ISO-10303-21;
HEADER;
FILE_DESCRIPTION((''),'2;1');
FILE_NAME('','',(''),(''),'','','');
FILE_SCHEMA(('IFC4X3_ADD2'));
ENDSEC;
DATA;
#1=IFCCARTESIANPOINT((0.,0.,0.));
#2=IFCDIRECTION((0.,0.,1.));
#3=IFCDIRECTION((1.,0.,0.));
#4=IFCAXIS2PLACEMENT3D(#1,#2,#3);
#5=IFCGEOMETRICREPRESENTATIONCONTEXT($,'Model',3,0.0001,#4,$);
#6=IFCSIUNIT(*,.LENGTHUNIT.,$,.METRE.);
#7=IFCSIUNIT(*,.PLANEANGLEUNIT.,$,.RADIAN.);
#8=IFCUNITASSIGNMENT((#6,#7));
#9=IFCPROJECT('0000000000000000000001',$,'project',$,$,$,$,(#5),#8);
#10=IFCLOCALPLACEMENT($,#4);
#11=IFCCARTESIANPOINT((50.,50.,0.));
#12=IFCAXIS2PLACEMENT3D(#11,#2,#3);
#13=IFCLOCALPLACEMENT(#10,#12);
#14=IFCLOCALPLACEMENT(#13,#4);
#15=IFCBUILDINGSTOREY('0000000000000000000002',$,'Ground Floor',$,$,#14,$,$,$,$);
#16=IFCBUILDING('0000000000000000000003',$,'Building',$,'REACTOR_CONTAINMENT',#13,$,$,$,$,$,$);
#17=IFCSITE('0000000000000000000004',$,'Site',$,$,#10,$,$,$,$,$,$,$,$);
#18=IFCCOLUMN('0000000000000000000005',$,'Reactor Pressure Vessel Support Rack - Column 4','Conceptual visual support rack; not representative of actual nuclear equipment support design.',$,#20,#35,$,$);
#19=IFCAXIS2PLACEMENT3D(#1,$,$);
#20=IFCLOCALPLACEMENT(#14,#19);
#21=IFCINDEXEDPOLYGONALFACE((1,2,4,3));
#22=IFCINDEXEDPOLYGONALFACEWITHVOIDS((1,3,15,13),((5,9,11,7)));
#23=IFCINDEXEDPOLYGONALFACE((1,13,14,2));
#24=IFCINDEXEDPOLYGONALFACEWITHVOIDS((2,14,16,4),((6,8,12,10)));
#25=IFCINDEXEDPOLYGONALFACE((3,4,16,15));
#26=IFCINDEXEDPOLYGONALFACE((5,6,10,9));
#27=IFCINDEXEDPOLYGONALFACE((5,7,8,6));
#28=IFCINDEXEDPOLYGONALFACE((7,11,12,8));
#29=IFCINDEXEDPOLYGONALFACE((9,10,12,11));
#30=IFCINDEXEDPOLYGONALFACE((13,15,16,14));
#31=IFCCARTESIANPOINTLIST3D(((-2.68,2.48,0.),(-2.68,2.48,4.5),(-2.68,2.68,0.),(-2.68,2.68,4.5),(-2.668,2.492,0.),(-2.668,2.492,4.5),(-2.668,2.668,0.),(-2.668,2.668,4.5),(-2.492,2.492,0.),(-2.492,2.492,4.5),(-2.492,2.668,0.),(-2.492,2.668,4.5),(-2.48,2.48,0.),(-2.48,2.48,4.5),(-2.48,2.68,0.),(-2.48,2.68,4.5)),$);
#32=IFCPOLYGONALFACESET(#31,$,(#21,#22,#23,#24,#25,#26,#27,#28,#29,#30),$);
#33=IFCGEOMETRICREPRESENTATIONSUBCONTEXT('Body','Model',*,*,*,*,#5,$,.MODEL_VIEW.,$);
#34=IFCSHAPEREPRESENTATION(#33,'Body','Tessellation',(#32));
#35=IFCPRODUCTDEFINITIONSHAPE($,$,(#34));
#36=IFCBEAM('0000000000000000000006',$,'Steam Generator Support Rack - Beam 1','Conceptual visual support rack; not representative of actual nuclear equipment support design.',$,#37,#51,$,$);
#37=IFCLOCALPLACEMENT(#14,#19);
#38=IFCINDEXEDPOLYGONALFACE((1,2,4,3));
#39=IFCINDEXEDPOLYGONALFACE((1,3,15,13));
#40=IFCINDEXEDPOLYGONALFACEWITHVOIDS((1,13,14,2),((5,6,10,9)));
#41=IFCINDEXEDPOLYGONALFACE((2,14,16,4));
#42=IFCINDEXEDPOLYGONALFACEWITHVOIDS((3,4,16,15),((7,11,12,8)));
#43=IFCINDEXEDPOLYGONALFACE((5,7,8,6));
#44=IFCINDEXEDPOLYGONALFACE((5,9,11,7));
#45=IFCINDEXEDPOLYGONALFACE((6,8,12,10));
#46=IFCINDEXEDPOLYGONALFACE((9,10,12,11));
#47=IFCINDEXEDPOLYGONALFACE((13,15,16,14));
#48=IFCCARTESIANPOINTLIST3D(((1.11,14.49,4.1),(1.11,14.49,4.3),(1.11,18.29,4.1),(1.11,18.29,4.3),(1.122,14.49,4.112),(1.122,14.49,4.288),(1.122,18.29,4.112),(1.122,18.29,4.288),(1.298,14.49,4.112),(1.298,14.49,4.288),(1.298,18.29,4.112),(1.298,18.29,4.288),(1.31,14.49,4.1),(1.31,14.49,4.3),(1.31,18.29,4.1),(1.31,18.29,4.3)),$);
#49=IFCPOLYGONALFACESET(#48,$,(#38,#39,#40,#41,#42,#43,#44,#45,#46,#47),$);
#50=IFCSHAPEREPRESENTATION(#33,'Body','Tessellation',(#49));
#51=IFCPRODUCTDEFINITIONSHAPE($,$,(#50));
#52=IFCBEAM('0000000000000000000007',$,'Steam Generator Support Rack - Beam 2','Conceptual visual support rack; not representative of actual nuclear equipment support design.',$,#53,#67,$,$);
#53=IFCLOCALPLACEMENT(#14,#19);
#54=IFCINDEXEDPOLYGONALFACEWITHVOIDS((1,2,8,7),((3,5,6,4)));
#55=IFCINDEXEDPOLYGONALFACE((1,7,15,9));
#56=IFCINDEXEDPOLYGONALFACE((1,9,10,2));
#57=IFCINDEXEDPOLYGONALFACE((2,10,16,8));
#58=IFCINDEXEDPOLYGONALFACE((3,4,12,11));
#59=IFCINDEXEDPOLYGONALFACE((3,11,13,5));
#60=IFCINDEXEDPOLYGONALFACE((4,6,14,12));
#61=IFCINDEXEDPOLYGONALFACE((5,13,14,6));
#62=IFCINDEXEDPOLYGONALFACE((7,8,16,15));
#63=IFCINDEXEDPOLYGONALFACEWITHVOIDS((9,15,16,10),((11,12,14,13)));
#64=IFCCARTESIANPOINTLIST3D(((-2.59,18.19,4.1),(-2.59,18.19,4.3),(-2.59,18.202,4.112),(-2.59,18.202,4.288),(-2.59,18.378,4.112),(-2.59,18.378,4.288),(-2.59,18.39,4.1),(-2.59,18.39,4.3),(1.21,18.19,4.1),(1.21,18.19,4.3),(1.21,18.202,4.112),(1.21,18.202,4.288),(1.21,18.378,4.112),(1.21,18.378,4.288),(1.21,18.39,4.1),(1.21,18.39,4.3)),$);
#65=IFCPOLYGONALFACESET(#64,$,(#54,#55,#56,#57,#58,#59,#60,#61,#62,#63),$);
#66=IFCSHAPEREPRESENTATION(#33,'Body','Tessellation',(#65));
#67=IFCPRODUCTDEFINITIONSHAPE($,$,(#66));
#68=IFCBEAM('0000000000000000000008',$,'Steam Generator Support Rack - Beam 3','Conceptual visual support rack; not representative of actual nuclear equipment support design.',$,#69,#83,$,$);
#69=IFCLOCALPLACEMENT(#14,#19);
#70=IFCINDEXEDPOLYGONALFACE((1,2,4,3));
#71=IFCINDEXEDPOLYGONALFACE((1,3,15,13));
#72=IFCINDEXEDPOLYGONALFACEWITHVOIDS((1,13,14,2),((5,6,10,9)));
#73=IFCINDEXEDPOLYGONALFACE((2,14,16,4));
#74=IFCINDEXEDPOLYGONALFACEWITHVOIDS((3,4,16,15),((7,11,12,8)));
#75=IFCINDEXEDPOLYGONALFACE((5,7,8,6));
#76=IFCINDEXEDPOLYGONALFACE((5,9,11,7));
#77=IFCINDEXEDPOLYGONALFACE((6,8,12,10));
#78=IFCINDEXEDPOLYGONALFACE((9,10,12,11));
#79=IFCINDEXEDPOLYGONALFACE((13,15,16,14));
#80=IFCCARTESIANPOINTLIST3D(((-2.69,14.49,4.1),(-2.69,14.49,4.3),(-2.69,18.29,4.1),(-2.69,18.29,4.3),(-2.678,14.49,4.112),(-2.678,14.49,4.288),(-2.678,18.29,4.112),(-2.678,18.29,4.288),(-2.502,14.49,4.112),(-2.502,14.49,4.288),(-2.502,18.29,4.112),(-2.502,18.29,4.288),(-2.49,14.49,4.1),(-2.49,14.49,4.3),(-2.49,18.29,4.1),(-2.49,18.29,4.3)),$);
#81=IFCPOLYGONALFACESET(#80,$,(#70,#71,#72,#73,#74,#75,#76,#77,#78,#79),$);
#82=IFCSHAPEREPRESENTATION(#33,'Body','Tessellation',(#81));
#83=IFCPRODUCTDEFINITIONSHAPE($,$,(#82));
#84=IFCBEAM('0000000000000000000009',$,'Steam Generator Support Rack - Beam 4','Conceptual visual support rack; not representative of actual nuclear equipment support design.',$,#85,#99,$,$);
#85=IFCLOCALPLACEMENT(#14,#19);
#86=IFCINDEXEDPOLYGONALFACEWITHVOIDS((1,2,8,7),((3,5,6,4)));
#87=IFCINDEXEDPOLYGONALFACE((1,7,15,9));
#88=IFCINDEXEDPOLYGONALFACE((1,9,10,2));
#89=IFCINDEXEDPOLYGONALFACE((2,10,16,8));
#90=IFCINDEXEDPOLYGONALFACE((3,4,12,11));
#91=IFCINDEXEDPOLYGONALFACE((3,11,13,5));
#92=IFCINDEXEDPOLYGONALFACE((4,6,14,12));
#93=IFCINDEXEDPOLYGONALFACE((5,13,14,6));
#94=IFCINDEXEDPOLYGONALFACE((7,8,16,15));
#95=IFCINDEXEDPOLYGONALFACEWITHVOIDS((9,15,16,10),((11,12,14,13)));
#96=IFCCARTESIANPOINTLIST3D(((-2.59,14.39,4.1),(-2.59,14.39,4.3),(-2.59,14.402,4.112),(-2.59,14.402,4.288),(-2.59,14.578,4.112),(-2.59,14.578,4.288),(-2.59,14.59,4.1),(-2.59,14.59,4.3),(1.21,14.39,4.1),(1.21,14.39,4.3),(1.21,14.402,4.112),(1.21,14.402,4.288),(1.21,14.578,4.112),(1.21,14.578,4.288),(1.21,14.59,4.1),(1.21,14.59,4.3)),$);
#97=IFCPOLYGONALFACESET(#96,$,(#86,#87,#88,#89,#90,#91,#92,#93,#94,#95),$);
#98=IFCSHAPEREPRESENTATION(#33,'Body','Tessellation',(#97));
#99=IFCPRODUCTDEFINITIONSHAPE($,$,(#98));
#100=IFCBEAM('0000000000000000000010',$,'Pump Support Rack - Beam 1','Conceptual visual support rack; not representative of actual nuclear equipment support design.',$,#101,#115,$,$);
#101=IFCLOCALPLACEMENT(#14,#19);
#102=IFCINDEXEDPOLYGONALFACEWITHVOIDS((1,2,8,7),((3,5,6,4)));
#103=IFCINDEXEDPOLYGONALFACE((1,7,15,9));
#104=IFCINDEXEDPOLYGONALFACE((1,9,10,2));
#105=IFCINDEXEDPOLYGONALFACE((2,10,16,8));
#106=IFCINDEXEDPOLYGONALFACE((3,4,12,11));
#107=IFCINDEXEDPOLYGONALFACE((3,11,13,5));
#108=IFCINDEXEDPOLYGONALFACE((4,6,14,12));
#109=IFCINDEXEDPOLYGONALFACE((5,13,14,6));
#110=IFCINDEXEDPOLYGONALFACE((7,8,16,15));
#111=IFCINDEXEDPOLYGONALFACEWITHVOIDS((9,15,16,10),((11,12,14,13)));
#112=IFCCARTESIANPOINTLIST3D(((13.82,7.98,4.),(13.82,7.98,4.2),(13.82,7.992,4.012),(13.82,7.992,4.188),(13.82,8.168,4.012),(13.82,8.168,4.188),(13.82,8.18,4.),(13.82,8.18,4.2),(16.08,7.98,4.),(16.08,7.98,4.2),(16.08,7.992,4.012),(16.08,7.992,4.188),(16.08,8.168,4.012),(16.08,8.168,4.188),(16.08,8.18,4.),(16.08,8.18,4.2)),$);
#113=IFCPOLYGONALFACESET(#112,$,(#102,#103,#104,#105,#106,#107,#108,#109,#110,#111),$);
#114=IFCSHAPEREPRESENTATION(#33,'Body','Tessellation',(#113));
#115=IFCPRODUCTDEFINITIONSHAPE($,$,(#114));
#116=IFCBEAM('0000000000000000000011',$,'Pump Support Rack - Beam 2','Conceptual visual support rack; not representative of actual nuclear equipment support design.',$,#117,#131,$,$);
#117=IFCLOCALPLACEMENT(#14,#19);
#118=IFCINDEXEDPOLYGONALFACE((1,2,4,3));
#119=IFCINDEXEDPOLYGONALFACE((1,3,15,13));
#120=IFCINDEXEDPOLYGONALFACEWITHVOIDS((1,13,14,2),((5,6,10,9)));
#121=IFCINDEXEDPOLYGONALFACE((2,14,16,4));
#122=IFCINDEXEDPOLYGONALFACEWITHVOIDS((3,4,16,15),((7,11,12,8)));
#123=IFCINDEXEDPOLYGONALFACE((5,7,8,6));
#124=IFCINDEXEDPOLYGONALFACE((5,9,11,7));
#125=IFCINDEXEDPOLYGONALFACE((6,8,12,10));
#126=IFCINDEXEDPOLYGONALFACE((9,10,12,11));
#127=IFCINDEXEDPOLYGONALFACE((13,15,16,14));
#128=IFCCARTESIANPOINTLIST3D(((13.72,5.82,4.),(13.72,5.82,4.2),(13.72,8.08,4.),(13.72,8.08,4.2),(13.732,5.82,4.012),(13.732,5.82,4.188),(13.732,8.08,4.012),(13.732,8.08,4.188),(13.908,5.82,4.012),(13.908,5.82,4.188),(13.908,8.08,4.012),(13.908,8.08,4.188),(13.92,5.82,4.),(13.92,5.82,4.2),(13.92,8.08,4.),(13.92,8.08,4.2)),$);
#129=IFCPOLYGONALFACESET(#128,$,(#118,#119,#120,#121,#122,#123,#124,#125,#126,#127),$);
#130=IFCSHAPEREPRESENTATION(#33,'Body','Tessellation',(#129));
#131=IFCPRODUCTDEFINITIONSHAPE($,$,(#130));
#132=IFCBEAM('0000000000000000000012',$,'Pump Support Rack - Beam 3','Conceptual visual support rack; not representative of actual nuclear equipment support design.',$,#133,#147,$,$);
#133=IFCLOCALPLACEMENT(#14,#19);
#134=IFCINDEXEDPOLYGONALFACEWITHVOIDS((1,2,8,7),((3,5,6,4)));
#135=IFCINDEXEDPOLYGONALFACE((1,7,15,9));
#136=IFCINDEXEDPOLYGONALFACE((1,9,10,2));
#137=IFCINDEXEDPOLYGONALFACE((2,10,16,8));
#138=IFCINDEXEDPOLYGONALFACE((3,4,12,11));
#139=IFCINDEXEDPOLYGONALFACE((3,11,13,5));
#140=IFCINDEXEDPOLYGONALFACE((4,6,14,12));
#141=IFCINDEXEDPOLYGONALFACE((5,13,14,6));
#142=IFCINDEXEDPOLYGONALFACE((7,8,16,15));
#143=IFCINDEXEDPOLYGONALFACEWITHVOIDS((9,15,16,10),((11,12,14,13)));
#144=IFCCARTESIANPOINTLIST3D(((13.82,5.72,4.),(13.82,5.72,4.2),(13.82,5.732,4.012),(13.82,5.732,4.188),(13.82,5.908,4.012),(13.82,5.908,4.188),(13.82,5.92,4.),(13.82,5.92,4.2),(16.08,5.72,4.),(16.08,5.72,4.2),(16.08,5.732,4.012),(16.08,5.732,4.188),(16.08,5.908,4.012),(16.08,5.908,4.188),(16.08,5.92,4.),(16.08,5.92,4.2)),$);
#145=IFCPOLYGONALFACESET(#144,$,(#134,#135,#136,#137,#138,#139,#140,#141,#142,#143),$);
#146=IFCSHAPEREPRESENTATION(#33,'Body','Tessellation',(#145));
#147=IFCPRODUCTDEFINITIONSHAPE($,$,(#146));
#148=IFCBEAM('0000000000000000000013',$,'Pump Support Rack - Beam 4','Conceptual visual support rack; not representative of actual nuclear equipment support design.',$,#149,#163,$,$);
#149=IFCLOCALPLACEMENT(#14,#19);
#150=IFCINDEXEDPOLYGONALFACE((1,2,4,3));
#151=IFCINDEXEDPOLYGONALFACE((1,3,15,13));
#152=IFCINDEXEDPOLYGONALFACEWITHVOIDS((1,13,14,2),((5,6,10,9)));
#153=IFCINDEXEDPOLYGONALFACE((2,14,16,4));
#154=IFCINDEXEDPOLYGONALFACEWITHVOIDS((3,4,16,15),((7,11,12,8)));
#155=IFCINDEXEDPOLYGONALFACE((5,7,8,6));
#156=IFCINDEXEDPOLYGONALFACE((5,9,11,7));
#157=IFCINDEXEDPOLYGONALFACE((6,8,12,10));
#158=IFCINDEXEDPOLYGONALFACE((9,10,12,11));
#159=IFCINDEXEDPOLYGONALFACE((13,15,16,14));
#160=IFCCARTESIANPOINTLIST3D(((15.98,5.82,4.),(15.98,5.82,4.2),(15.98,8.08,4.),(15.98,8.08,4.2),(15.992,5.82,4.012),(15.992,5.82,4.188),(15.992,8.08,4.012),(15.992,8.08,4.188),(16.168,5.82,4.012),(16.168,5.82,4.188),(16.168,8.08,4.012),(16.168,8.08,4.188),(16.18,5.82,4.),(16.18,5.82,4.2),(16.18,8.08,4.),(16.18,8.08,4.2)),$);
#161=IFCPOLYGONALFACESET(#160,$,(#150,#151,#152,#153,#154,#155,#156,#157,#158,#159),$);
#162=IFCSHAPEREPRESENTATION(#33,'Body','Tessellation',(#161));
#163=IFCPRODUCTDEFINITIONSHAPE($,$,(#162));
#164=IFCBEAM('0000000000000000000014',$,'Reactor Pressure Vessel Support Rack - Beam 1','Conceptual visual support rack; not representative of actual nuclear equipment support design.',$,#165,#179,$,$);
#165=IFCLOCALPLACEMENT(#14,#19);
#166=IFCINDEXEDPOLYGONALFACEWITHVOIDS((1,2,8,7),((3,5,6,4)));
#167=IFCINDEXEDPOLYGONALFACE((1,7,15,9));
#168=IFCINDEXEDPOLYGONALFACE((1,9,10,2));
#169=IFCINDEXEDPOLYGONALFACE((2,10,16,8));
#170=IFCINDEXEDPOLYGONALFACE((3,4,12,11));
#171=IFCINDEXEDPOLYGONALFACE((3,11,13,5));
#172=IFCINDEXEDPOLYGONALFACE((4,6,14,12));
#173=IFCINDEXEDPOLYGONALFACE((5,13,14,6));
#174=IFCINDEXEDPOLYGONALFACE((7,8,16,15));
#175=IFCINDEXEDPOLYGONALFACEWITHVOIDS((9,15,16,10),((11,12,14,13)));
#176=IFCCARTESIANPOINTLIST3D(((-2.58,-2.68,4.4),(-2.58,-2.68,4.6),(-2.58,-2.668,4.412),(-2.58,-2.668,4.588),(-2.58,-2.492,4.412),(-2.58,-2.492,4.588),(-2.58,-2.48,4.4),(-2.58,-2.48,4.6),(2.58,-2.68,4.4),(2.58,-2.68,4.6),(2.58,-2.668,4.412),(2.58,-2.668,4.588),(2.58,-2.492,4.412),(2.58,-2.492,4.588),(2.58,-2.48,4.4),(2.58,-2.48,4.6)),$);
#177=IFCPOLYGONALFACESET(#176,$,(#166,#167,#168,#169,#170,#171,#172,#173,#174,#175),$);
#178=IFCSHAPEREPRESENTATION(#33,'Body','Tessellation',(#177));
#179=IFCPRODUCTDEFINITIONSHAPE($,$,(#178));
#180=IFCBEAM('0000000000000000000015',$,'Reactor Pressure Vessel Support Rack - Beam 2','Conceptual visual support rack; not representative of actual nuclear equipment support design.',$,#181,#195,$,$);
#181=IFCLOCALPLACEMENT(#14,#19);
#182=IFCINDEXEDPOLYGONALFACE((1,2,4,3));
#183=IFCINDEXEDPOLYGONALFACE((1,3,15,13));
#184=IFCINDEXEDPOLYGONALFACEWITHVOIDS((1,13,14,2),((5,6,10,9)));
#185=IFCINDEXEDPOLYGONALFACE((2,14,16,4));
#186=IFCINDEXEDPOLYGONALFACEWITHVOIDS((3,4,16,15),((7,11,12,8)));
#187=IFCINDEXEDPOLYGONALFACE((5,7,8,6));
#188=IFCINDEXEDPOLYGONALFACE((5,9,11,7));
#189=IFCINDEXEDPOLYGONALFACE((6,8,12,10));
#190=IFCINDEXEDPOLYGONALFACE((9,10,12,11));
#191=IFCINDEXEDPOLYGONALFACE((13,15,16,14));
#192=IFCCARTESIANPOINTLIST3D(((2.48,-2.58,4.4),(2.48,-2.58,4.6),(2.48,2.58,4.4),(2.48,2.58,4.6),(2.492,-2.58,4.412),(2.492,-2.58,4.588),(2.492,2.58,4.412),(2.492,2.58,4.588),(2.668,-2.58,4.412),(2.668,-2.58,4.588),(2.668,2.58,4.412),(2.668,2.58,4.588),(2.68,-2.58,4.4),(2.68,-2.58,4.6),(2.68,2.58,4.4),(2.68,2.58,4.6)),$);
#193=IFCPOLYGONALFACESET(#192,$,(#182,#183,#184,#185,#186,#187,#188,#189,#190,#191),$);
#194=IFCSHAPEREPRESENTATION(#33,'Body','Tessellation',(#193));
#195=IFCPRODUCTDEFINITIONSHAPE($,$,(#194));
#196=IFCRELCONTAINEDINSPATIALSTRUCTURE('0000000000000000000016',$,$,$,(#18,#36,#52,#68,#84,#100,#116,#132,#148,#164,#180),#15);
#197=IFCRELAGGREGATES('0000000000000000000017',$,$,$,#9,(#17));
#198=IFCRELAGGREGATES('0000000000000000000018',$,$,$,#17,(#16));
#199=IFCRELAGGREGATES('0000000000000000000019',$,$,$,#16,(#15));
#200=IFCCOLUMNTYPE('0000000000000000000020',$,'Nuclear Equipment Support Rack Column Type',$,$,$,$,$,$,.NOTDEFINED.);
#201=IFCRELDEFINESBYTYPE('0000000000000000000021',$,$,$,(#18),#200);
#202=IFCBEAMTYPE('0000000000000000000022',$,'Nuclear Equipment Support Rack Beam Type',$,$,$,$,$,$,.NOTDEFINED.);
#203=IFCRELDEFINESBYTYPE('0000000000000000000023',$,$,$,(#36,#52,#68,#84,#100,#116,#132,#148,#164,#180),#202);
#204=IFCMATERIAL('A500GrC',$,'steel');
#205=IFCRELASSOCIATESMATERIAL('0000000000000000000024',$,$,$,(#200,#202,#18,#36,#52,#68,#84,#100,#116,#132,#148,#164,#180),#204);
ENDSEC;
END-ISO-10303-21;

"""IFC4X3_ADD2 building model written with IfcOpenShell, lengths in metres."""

from ifc_helpers import new_model, si_unit, frame, origin_with_axes, place, context, subcontext, project, spatial, hollow_rectangle, extrude, material, material_profile, profile_set, profile_usage, type_object, element, save


model = new_model("IFC4X3_ADD2")

# Units and contexts
model_context = context("Model", 3, precision=0.0001, world=origin_with_axes())
body_context = subcontext(model_context, "Body", "Model", "MODEL_VIEW")
ifc_project = project(units=[si_unit("LENGTHUNIT", "METRE"), si_unit("PLANEANGLEUNIT", "RADIAN")], contexts=[model_context])

# Site, building, storey
site_placement = place(None, origin_with_axes())
site = spatial("IfcSite", under=ifc_project, at=site_placement, Name="Site")
building_placement = place(site_placement, frame((50.0, 50.0, 0.0), z_axis=(0.0, 0.0, 1.0), x_axis=(1.0, 0.0, 0.0)))
building = spatial("IfcBuilding", under=site, at=building_placement, Name="Building", ObjectType="REACTOR_CONTAINMENT")
storey_placement = place(building_placement, origin_with_axes())
storey = spatial("IfcBuildingStorey", under=building, at=storey_placement, Name="Ground Floor")

# Column
ifc_material = material(Name="A500GrC", Category="steel")
ifc_material_profile = material_profile(ifc_material, hollow_rectangle(XDim=0.2, YDim=0.2, WallThickness=0.012))
ifc_profile_set = profile_set([ifc_material_profile], Name="A500GrC steel Nuclear Equipment Support Rack HSS")
column_type = type_object("IfcColumnType", Name="Nuclear Equipment Support Rack Column Type", PredefinedType="NOTDEFINED", material=ifc_profile_set)
ifc_profile_usage_1 = profile_usage(ifc_profile_set, cardinal=5)
column_1_placement = place(None, frame((47.42, 52.58, 0.0), z_axis=(0.0, 0.0, 1.0), x_axis=(0.0, -1.0, 0.0)))
element("IfcColumn", 1, at=column_1_placement, inside=storey, type_object=column_type, material=ifc_profile_usage_1, Name="Reactor Pressure Vessel Support Rack - Column 4", Description="Conceptual visual support rack; not representative of actual nuclear equipment support design.", context=body_context, shape_type="SweptSolid", body=[
    extrude(hollow_rectangle(XDim=0.2, YDim=0.2, WallThickness=0.012), origin_with_axes(), (0.0, 0.0, 1.0), 4.5),
])

# Beams
ifc_profile_usage_2 = profile_usage(ifc_profile_set, cardinal=5)
beam_type = type_object("IfcBeamType", Name="Nuclear Equipment Support Rack Beam Type", PredefinedType="NOTDEFINED", material=ifc_profile_set)
beam_1_placement = place(None, frame((51.21, 64.49, 4.2), z_axis=(0.0, 1.0, 0.0), x_axis=(-1.0, 0.0, 0.0)))
element("IfcBeam", 2, at=beam_1_placement, inside=storey, type_object=beam_type, material=ifc_profile_usage_2, Name="Steam Generator Support Rack - Beam 1", Description="Conceptual visual support rack; not representative of actual nuclear equipment support design.", context=body_context, shape_type="SweptSolid", body=[
    extrude(hollow_rectangle(XDim=0.2, YDim=0.2, WallThickness=0.012), origin_with_axes(), (0.0, 0.0, 1.0), 3.8),
])
ifc_profile_usage_3 = profile_usage(ifc_profile_set, cardinal=5)
beam_2_placement = place(None, frame((51.21, 68.29, 4.2), z_axis=(-1.0, 0.0, 0.0), x_axis=(0.0, -1.0, 0.0)))
element("IfcBeam", 3, at=beam_2_placement, inside=storey, type_object=beam_type, material=ifc_profile_usage_3, Name="Steam Generator Support Rack - Beam 2", Description="Conceptual visual support rack; not representative of actual nuclear equipment support design.", context=body_context, shape_type="SweptSolid", body=[
    extrude(hollow_rectangle(XDim=0.2, YDim=0.2, WallThickness=0.012), origin_with_axes(), (0.0, 0.0, 1.0), 3.8),
])
ifc_profile_usage_4 = profile_usage(ifc_profile_set, cardinal=5)
beam_3_placement = place(None, frame((47.41, 68.29, 4.2), z_axis=(0.0, -1.0, 0.0), x_axis=(1.0, 0.0, 0.0)))
element("IfcBeam", 4, at=beam_3_placement, inside=storey, type_object=beam_type, material=ifc_profile_usage_4, Name="Steam Generator Support Rack - Beam 3", Description="Conceptual visual support rack; not representative of actual nuclear equipment support design.", context=body_context, shape_type="SweptSolid", body=[
    extrude(hollow_rectangle(XDim=0.2, YDim=0.2, WallThickness=0.012), origin_with_axes(), (0.0, 0.0, 1.0), 3.8),
])
ifc_profile_usage_5 = profile_usage(ifc_profile_set, cardinal=5)
beam_4_placement = place(None, frame((47.41, 64.49, 4.2), z_axis=(1.0, 0.0, 0.0), x_axis=(0.0, 1.0, 0.0)))
element("IfcBeam", 5, at=beam_4_placement, inside=storey, type_object=beam_type, material=ifc_profile_usage_5, Name="Steam Generator Support Rack - Beam 4", Description="Conceptual visual support rack; not representative of actual nuclear equipment support design.", context=body_context, shape_type="SweptSolid", body=[
    extrude(hollow_rectangle(XDim=0.2, YDim=0.2, WallThickness=0.012), origin_with_axes(), (0.0, 0.0, 1.0), 3.8),
])
ifc_profile_usage_6 = profile_usage(ifc_profile_set, cardinal=5)
beam_5_placement = place(None, frame((66.08, 58.08, 4.1), z_axis=(-1.0, 0.0, 0.0), x_axis=(0.0, -1.0, 0.0)))
element("IfcBeam", 6, at=beam_5_placement, inside=storey, type_object=beam_type, material=ifc_profile_usage_6, Name="Pump Support Rack - Beam 1", Description="Conceptual visual support rack; not representative of actual nuclear equipment support design.", context=body_context, shape_type="SweptSolid", body=[
    extrude(hollow_rectangle(XDim=0.2, YDim=0.2, WallThickness=0.012), origin_with_axes(), (0.0, 0.0, 1.0), 2.26),
])
ifc_profile_usage_7 = profile_usage(ifc_profile_set, cardinal=5)
beam_6_placement = place(None, frame((63.82, 58.08, 4.1), z_axis=(0.0, -1.0, 0.0), x_axis=(1.0, 0.0, 0.0)))
element("IfcBeam", 7, at=beam_6_placement, inside=storey, type_object=beam_type, material=ifc_profile_usage_7, Name="Pump Support Rack - Beam 2", Description="Conceptual visual support rack; not representative of actual nuclear equipment support design.", context=body_context, shape_type="SweptSolid", body=[
    extrude(hollow_rectangle(XDim=0.2, YDim=0.2, WallThickness=0.012), origin_with_axes(), (0.0, 0.0, 1.0), 2.26),
])
ifc_profile_usage_8 = profile_usage(ifc_profile_set, cardinal=5)
beam_7_placement = place(None, frame((63.82, 55.82, 4.1), z_axis=(1.0, 0.0, 0.0), x_axis=(0.0, 1.0, 0.0)))
element("IfcBeam", 8, at=beam_7_placement, inside=storey, type_object=beam_type, material=ifc_profile_usage_8, Name="Pump Support Rack - Beam 3", Description="Conceptual visual support rack; not representative of actual nuclear equipment support design.", context=body_context, shape_type="SweptSolid", body=[
    extrude(hollow_rectangle(XDim=0.2, YDim=0.2, WallThickness=0.012), origin_with_axes(), (0.0, 0.0, 1.0), 2.26),
])
ifc_profile_usage_9 = profile_usage(ifc_profile_set, cardinal=5)
beam_8_placement = place(None, frame((66.08, 55.82, 4.1), z_axis=(0.0, 1.0, 0.0), x_axis=(-1.0, 0.0, 0.0)))
element("IfcBeam", 9, at=beam_8_placement, inside=storey, type_object=beam_type, material=ifc_profile_usage_9, Name="Pump Support Rack - Beam 4", Description="Conceptual visual support rack; not representative of actual nuclear equipment support design.", context=body_context, shape_type="SweptSolid", body=[
    extrude(hollow_rectangle(XDim=0.2, YDim=0.2, WallThickness=0.012), origin_with_axes(), (0.0, 0.0, 1.0), 2.26),
])
ifc_profile_usage_10 = profile_usage(ifc_profile_set, cardinal=5)
beam_9_placement = place(None, frame((47.42, 47.42, 4.5), z_axis=(1.0, 0.0, 0.0), x_axis=(0.0, 1.0, 0.0)))
element("IfcBeam", 10, at=beam_9_placement, inside=storey, type_object=beam_type, material=ifc_profile_usage_10, Name="Reactor Pressure Vessel Support Rack - Beam 1", Description="Conceptual visual support rack; not representative of actual nuclear equipment support design.", context=body_context, shape_type="SweptSolid", body=[
    extrude(hollow_rectangle(XDim=0.2, YDim=0.2, WallThickness=0.012), origin_with_axes(), (0.0, 0.0, 1.0), 5.16),
])
ifc_profile_usage_11 = profile_usage(ifc_profile_set, cardinal=5)
beam_10_placement = place(None, frame((52.58, 47.42, 4.5), z_axis=(0.0, 1.0, 0.0), x_axis=(-1.0, 0.0, 0.0)))
element("IfcBeam", 11, at=beam_10_placement, inside=storey, type_object=beam_type, material=ifc_profile_usage_11, Name="Reactor Pressure Vessel Support Rack - Beam 2", Description="Conceptual visual support rack; not representative of actual nuclear equipment support design.", context=body_context, shape_type="SweptSolid", body=[
    extrude(hollow_rectangle(XDim=0.2, YDim=0.2, WallThickness=0.012), origin_with_axes(), (0.0, 0.0, 1.0), 5.16),
])

save(model, "model.ifc")
